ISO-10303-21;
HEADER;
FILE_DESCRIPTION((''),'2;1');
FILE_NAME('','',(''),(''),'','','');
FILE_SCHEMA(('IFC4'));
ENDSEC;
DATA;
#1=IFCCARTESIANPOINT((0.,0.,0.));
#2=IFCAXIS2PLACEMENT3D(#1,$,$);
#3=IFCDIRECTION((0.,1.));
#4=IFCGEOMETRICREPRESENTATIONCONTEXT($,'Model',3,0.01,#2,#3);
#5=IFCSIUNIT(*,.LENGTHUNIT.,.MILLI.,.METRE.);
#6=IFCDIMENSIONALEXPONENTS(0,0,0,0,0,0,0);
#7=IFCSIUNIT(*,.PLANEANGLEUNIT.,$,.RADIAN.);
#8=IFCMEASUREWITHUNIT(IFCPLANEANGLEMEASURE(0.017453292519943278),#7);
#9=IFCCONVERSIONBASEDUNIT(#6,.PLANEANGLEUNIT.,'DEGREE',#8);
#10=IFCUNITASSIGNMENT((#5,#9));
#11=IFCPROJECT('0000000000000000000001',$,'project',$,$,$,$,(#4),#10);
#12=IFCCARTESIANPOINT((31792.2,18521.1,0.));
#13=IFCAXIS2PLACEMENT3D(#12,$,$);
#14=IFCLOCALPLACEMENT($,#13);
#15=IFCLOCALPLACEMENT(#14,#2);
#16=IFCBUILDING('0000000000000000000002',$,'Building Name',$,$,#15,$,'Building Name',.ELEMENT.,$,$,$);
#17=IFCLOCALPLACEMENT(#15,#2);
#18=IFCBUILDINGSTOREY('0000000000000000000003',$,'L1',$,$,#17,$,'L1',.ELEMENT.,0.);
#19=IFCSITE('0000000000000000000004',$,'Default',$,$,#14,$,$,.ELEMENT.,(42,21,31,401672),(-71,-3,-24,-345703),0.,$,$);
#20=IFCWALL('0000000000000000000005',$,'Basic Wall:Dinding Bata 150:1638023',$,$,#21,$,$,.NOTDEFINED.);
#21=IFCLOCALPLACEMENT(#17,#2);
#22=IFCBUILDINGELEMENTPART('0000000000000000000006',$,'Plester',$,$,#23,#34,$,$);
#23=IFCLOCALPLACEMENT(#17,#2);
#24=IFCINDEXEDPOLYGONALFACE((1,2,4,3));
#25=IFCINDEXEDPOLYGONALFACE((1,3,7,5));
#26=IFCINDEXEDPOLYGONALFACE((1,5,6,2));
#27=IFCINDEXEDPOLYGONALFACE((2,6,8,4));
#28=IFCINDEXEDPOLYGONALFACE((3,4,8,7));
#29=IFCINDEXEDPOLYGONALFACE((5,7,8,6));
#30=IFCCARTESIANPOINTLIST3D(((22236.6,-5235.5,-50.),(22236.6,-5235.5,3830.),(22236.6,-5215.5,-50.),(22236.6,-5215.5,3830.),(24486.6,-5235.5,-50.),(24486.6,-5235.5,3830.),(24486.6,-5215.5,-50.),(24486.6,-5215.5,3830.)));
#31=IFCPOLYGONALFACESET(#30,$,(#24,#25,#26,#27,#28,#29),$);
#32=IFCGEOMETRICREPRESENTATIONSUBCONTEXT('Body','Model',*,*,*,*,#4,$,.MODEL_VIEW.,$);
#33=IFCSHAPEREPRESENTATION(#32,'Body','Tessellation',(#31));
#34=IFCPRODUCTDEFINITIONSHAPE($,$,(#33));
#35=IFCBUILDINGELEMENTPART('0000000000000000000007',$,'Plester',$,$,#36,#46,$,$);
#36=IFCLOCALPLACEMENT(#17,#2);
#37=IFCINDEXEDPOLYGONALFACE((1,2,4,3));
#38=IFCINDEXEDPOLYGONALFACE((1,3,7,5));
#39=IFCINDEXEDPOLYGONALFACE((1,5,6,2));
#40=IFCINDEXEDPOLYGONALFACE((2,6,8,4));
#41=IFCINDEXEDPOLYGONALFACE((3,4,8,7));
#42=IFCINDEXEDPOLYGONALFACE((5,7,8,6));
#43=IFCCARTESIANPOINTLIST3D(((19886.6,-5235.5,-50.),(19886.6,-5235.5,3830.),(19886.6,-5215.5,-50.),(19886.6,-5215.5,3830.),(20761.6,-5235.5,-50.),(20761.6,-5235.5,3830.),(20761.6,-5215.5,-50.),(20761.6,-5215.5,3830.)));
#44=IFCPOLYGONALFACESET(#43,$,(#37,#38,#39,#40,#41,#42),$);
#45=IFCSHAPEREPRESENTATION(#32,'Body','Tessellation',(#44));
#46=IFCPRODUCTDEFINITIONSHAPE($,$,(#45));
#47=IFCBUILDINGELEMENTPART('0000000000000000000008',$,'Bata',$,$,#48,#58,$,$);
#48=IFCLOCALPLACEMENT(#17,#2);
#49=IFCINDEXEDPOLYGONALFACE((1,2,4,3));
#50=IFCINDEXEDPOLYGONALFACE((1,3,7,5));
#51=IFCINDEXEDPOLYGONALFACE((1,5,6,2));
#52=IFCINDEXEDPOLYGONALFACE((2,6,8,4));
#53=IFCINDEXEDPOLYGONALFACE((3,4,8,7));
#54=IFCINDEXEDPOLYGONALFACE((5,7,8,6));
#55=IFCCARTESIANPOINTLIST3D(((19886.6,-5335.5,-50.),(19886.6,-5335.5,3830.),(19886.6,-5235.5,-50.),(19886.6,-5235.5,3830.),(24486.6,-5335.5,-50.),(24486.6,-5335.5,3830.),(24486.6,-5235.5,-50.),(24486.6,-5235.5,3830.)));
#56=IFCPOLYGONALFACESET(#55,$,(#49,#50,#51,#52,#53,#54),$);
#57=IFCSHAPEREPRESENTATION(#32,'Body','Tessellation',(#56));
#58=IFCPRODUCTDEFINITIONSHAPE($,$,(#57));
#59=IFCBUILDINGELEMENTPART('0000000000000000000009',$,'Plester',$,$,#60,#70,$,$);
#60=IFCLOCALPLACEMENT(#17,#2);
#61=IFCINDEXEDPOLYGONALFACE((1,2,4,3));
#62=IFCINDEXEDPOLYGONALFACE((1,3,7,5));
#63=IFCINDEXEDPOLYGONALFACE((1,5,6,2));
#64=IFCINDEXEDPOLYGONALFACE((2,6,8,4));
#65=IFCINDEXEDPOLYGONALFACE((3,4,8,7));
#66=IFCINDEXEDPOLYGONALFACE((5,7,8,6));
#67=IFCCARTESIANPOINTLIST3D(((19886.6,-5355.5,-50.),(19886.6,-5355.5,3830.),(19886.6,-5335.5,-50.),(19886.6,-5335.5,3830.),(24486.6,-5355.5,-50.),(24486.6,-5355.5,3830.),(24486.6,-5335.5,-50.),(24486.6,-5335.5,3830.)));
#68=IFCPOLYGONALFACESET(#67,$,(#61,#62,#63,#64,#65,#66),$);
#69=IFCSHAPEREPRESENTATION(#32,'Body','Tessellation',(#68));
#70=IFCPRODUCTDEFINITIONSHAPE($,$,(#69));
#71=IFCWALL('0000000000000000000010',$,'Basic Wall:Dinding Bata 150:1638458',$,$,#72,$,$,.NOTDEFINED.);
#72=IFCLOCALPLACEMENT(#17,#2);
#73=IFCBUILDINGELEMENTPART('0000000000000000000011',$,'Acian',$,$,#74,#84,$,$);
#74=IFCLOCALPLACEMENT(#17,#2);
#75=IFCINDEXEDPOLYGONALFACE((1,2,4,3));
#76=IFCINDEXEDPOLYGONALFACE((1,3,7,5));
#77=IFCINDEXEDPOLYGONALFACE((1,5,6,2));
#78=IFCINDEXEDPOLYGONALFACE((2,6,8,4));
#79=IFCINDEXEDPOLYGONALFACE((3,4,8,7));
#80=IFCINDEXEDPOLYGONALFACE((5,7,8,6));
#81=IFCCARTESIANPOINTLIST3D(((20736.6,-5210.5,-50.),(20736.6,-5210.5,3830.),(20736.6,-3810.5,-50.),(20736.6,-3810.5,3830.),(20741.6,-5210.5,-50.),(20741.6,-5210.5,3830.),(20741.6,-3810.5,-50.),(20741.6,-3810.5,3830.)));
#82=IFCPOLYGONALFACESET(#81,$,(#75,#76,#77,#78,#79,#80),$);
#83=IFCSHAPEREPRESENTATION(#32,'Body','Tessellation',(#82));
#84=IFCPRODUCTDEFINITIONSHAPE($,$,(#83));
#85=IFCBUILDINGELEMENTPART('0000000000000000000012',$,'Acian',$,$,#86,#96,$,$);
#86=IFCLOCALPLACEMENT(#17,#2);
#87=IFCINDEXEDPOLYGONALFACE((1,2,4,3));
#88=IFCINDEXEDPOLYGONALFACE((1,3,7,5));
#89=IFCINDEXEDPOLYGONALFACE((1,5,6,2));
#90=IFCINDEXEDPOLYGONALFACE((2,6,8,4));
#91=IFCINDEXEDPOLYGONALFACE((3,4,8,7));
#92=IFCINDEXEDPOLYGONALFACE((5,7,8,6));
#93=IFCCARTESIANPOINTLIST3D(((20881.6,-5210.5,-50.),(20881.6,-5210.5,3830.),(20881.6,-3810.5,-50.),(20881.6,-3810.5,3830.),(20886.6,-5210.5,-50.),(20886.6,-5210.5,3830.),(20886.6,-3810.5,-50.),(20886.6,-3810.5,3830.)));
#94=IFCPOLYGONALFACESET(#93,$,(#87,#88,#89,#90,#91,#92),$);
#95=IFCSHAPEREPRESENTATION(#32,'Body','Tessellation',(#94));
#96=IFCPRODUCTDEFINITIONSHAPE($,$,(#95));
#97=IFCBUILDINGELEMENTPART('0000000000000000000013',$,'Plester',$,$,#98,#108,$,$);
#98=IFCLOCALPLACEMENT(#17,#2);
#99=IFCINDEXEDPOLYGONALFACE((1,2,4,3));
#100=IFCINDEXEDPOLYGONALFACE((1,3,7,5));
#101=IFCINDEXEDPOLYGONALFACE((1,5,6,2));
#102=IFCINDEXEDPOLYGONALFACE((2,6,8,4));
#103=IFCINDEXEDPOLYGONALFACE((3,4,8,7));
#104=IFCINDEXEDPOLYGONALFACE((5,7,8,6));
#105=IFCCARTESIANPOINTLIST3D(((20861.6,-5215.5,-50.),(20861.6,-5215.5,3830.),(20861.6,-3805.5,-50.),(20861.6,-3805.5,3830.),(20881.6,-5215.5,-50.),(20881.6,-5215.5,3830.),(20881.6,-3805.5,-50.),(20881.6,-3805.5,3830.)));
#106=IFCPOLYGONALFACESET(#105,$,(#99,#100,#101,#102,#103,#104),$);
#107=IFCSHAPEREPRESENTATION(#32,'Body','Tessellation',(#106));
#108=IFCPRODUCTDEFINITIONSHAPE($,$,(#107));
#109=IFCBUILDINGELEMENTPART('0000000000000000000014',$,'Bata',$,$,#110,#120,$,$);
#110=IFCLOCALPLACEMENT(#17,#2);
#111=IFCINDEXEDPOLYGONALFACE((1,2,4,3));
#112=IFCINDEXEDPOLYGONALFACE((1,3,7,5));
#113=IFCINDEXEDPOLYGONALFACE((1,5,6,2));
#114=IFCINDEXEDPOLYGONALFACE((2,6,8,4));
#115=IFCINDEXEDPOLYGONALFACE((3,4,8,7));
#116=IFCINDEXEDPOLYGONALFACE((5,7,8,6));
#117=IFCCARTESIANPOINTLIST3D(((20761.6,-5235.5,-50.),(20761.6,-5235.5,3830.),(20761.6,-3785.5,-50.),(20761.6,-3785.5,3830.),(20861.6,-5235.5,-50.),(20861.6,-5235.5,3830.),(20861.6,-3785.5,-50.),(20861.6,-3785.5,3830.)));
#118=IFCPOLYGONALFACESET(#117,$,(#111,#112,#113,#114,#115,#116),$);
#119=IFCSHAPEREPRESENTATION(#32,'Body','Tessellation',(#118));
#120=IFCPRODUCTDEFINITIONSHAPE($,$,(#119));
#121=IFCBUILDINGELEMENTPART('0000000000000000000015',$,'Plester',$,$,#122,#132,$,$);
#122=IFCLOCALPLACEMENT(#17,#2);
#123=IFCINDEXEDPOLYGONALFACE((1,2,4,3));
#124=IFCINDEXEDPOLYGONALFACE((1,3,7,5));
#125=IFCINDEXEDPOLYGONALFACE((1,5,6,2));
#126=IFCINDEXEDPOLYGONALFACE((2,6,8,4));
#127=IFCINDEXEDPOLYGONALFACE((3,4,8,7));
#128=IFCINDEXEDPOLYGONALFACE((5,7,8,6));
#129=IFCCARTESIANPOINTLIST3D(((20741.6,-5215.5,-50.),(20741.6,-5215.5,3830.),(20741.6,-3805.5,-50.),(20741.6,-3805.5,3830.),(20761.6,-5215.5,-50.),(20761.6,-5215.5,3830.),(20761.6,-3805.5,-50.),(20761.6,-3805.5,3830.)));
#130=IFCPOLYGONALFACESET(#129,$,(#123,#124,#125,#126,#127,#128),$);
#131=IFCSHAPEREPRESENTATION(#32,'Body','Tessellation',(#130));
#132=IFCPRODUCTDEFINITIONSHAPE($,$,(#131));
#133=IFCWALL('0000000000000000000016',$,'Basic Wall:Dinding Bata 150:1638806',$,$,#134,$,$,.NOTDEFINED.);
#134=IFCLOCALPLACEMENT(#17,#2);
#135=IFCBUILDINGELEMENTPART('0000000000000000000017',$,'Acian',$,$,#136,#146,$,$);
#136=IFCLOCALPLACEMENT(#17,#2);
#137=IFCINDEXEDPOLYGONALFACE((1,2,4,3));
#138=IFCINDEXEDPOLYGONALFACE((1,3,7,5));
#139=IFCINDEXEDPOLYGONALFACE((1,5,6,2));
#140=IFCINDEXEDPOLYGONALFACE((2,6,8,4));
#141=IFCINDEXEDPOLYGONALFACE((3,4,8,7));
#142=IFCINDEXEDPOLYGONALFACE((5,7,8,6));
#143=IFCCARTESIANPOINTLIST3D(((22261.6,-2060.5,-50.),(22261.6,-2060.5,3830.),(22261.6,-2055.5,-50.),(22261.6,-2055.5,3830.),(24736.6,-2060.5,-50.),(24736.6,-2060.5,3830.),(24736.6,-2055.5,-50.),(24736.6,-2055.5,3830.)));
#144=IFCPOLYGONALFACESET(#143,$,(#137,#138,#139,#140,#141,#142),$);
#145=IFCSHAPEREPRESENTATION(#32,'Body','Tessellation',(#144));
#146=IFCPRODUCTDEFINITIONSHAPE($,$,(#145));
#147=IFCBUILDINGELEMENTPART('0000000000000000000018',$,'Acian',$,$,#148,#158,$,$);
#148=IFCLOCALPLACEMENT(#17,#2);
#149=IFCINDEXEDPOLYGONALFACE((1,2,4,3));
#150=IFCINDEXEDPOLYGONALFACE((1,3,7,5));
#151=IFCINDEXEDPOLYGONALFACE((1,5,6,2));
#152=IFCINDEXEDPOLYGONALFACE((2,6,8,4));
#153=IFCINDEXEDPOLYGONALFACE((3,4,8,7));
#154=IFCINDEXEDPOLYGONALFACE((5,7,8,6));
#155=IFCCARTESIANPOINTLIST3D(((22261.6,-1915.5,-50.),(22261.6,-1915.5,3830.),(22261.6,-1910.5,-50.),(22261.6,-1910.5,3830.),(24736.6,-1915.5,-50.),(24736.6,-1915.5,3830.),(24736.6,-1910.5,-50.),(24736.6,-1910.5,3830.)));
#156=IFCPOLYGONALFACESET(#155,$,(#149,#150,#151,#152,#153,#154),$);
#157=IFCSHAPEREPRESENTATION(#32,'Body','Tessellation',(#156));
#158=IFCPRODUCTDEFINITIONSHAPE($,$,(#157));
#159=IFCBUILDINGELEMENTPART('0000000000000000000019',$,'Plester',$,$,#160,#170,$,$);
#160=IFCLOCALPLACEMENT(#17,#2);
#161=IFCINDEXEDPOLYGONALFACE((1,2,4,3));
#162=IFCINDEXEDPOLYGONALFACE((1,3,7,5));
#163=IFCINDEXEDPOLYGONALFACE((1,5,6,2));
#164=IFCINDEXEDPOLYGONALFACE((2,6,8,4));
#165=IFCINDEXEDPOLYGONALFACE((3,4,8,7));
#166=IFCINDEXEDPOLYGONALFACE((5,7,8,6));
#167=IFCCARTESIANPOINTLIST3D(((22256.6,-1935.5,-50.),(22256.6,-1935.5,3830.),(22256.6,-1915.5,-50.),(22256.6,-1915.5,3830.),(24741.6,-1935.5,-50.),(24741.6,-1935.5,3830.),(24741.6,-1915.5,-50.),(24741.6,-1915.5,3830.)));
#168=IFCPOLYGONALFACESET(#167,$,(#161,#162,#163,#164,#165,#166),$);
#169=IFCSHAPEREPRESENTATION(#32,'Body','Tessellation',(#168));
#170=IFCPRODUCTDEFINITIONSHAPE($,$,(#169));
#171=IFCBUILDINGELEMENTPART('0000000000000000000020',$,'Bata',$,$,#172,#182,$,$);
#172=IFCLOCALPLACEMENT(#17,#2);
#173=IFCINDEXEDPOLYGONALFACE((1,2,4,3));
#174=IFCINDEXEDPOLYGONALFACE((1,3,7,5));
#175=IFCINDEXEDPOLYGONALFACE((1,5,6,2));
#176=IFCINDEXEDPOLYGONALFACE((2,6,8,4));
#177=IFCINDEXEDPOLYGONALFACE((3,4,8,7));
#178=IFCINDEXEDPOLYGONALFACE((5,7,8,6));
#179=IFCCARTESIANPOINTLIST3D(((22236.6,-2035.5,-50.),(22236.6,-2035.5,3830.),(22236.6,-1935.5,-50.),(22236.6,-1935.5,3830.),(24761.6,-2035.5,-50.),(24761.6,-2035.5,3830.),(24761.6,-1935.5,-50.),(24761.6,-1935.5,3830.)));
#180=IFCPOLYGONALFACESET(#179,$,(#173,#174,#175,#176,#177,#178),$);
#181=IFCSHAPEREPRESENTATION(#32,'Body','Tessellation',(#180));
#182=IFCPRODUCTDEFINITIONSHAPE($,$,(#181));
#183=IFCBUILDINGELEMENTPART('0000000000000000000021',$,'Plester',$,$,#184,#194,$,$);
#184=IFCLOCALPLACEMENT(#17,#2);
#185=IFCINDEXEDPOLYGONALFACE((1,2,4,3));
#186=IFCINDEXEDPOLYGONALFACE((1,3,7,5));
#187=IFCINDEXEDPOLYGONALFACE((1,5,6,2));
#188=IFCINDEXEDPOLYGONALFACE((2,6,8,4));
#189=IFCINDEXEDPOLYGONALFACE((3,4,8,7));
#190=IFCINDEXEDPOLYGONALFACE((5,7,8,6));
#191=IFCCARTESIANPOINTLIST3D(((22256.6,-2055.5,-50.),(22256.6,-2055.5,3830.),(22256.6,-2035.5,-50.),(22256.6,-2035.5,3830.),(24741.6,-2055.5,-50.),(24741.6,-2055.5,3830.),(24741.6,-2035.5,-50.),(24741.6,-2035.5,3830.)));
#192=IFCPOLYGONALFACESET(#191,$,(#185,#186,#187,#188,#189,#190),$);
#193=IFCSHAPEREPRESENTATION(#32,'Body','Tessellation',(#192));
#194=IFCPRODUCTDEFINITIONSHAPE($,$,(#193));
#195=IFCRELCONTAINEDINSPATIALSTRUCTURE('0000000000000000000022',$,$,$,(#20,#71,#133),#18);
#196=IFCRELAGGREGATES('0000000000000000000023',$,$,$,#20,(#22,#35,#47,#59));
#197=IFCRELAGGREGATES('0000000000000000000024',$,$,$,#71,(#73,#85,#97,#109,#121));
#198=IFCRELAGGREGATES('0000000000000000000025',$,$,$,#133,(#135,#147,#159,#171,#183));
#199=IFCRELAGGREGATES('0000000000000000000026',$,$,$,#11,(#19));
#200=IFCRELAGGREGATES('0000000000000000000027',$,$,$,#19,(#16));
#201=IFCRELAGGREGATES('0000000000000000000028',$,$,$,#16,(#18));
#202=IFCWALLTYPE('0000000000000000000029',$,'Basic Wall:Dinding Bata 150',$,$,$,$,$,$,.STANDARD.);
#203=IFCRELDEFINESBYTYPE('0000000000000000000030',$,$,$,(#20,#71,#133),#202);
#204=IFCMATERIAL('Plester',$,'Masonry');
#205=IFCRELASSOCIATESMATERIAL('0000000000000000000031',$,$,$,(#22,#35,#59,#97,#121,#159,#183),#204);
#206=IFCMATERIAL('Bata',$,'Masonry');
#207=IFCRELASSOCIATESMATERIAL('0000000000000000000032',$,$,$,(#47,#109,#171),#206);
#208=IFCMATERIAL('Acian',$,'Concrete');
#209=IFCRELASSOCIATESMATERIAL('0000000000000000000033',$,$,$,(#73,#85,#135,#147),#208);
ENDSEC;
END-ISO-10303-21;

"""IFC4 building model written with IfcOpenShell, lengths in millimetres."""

from ifc_helpers import new_model, entity, si_unit, converted_unit, direction, frame, origin, place, context, subcontext, project, spatial, indexed_curve, outline, extrude, material, type_object, element, aggregate, save


model = new_model("IFC4")

# Units and contexts
model_context = context("Model", 3, precision=0.01, world=origin(), true_north=direction((0.0, 1.0)))
body_context = subcontext(model_context, "Body", "Model", "MODEL_VIEW")
ifc_project = project(units=[si_unit("LENGTHUNIT", "METRE", prefix="MILLI"), converted_unit("PLANEANGLEUNIT", "DEGREE", entity("IfcPlaneAngleMeasure", 0.017453292519943278), si_unit("PLANEANGLEUNIT", "RADIAN"), dimensions=[0, 0, 0, 0, 0, 0, 0])], contexts=[model_context])

# Site, building, storey
site_placement = place(None, frame((31792.2, 18521.1, 0.0)))
site = spatial("IfcSite", under=ifc_project, at=site_placement, Name="Default", CompositionType="ELEMENT", RefLatitude=(42, 21, 31, 401672), RefLongitude=(-71, -3, -24, -345703), RefElevation=0.0)
building_placement = place(site_placement, origin())
building = spatial("IfcBuilding", under=site, at=building_placement, Name="Building Name", LongName="Building Name", CompositionType="ELEMENT")
storey_placement = place(building_placement, origin())
storey = spatial("IfcBuildingStorey", under=building, at=storey_placement, Name="L1", LongName="L1", CompositionType="ELEMENT", Elevation=0.0)

# Walls, building element parts
wall_type = type_object("IfcWallType", Name="Basic Wall:Dinding Bata 150", PredefinedType="STANDARD")
wall_1_placement = place(storey_placement, frame((19886.6, -5285.5, -50.0)))
wall_1 = element("IfcWall", 1, at=wall_1_placement, inside=storey, type_object=wall_type, Name="Basic Wall:Dinding Bata 150:1638023", PredefinedType="NOTDEFINED")
ifc_material_1 = material(Name="Plester", Category="Masonry")
building_element_part_1_placement = place(wall_1_placement, origin())
building_element_part_1 = element("IfcBuildingElementPart", 2, at=building_element_part_1_placement, material=ifc_material_1, Name="Plester", context=body_context, shape_type="SweptSolid", body=[
    extrude(outline(indexed_curve([(-10.0, -1125.0), (10.0, -1125.0), (10.0, 1125.0), (-10.0, 1125.0), (-10.0, -1125.0)], self_intersect=False)), frame((3475.0, 60.0, 0.0), z_axis=(0.0, 0.0, 1.0), x_axis=(0.0, -1.0, 0.0)), (0.0, 0.0, 1.0), 3880.0),
])
building_element_part_2_placement = place(wall_1_placement, origin())
building_element_part_2 = element("IfcBuildingElementPart", 3, at=building_element_part_2_placement, material=ifc_material_1, Name="Plester", context=body_context, shape_type="SweptSolid", body=[
    extrude(outline(indexed_curve([(-10.0, -437.5), (10.0, -437.5), (10.0, 437.5), (-10.0, 437.5), (-10.0, -437.5)], self_intersect=False)), frame((437.5, 60.0, 0.0), z_axis=(0.0, 0.0, 1.0), x_axis=(0.0, -1.0, 0.0)), (0.0, 0.0, 1.0), 3880.0),
])
ifc_material_2 = material(Name="Bata", Category="Masonry")
building_element_part_3_placement = place(wall_1_placement, origin())
building_element_part_3 = element("IfcBuildingElementPart", 4, at=building_element_part_3_placement, material=ifc_material_2, Name="Bata", context=body_context, shape_type="SweptSolid", body=[
    extrude(outline(indexed_curve([(-50.0, -2300.0), (50.0, -2300.0), (50.0, 2300.0), (-50.0, 2300.0), (-50.0, -2300.0)], self_intersect=False)), frame((2300.0, 0.0, 0.0), z_axis=(0.0, 0.0, 1.0), x_axis=(0.0, -1.0, 0.0)), (0.0, 0.0, 1.0), 3880.0),
])
building_element_part_4_placement = place(wall_1_placement, origin())
building_element_part_4 = element("IfcBuildingElementPart", 5, at=building_element_part_4_placement, material=ifc_material_1, Name="Plester", context=body_context, shape_type="SweptSolid", body=[
    extrude(outline(indexed_curve([(-10.0, -2300.0), (10.0, -2300.0), (10.0, 2300.0), (-10.0, 2300.0), (-10.0, -2300.0)], self_intersect=False)), frame((2300.0, -60.0, 0.0), z_axis=(0.0, 0.0, 1.0), x_axis=(0.0, -1.0, 0.0)), (0.0, 0.0, 1.0), 3880.0),
])
aggregate(wall_1, [building_element_part_1, building_element_part_2, building_element_part_3, building_element_part_4])
wall_2_placement = place(storey_placement, frame((20811.6, -3810.5, -50.0), z_axis=(0.0, 0.0, 1.0), x_axis=(0.0, -1.0, 0.0)))
wall_2 = element("IfcWall", 6, at=wall_2_placement, inside=storey, type_object=wall_type, Name="Basic Wall:Dinding Bata 150:1638458", PredefinedType="NOTDEFINED")
ifc_material_3 = material(Name="Acian", Category="Concrete")
building_element_part_5_placement = place(wall_2_placement, origin())
building_element_part_5 = element("IfcBuildingElementPart", 7, at=building_element_part_5_placement, material=ifc_material_3, Name="Acian", context=body_context, shape_type="SweptSolid", body=[
    extrude(outline(indexed_curve([(-700.0, -2.5), (700.0, -2.5), (700.0, 2.5), (-700.0, 2.5), (-700.0, -2.5)], self_intersect=False)), frame((700.0, -72.5, 0.0)), (0.0, 0.0, 1.0), 3880.0),
])
building_element_part_6_placement = place(wall_2_placement, origin())
building_element_part_6 = element("IfcBuildingElementPart", 8, at=building_element_part_6_placement, material=ifc_material_3, Name="Acian", context=body_context, shape_type="SweptSolid", body=[
    extrude(outline(indexed_curve([(-700.0, -2.5), (700.0, -2.5), (700.0, 2.5), (-700.0, 2.5), (-700.0, -2.5)], self_intersect=False)), frame((700.0, 72.5, 0.0)), (0.0, 0.0, 1.0), 3880.0),
])
building_element_part_7_placement = place(wall_2_placement, origin())
building_element_part_7 = element("IfcBuildingElementPart", 9, at=building_element_part_7_placement, material=ifc_material_1, Name="Plester", context=body_context, shape_type="SweptSolid", body=[
    extrude(outline(indexed_curve([(-705.0, -10.0), (705.0, -10.0), (705.0, 10.0), (-705.0, 10.0), (-705.0, -10.0)], self_intersect=False)), frame((700.0, 60.0, 0.0)), (0.0, 0.0, 1.0), 3880.0),
])
building_element_part_8_placement = place(wall_2_placement, origin())
building_element_part_8 = element("IfcBuildingElementPart", 10, at=building_element_part_8_placement, material=ifc_material_2, Name="Bata", context=body_context, shape_type="SweptSolid", body=[
    extrude(outline(indexed_curve([(-725.0, -50.0), (725.0, -50.0), (725.0, 50.0), (-725.0, 50.0), (-725.0, -50.0)], self_intersect=False)), frame((700.0, 0.0, 0.0)), (0.0, 0.0, 1.0), 3880.0),
])
building_element_part_9_placement = place(wall_2_placement, origin())
building_element_part_9 = element("IfcBuildingElementPart", 11, at=building_element_part_9_placement, material=ifc_material_1, Name="Plester", context=body_context, shape_type="SweptSolid", body=[
    extrude(outline(indexed_curve([(-705.0, -10.0), (705.0, -10.0), (705.0, 10.0), (-705.0, 10.0), (-705.0, -10.0)], self_intersect=False)), frame((700.0, -60.0, 0.0)), (0.0, 0.0, 1.0), 3880.0),
])
aggregate(wall_2, [building_element_part_5, building_element_part_6, building_element_part_7, building_element_part_8, building_element_part_9])
wall_3_placement = place(storey_placement, frame((22261.6, -1985.5, -50.0)))
wall_3 = element("IfcWall", 12, at=wall_3_placement, inside=storey, type_object=wall_type, Name="Basic Wall:Dinding Bata 150:1638806", PredefinedType="NOTDEFINED")
building_element_part_10_placement = place(wall_3_placement, origin())
building_element_part_10 = element("IfcBuildingElementPart", 13, at=building_element_part_10_placement, material=ifc_material_3, Name="Acian", context=body_context, shape_type="SweptSolid", body=[
    extrude(outline(indexed_curve([(-2.5, -1237.5), (2.5, -1237.5), (2.5, 1237.5), (-2.5, 1237.5), (-2.5, -1237.5)], self_intersect=False)), frame((1237.5, -72.5, 0.0), z_axis=(0.0, 0.0, 1.0), x_axis=(0.0, -1.0, 0.0)), (0.0, 0.0, 1.0), 3880.0),
])
building_element_part_11_placement = place(wall_3_placement, origin())
building_element_part_11 = element("IfcBuildingElementPart", 14, at=building_element_part_11_placement, material=ifc_material_3, Name="Acian", context=body_context, shape_type="SweptSolid", body=[
    extrude(outline(indexed_curve([(-2.5, -1237.5), (2.5, -1237.5), (2.5, 1237.5), (-2.5, 1237.5), (-2.5, -1237.5)], self_intersect=False)), frame((1237.5, 72.5, 0.0), z_axis=(0.0, 0.0, 1.0), x_axis=(0.0, -1.0, 0.0)), (0.0, 0.0, 1.0), 3880.0),
])
building_element_part_12_placement = place(wall_3_placement, origin())
building_element_part_12 = element("IfcBuildingElementPart", 15, at=building_element_part_12_placement, material=ifc_material_1, Name="Plester", context=body_context, shape_type="SweptSolid", body=[
    extrude(outline(indexed_curve([(-10.0, -1242.5), (10.0, -1242.5), (10.0, 1242.5), (-10.0, 1242.5), (-10.0, -1242.5)], self_intersect=False)), frame((1237.5, 60.0, 0.0), z_axis=(0.0, 0.0, 1.0), x_axis=(0.0, -1.0, 0.0)), (0.0, 0.0, 1.0), 3880.0),
])
building_element_part_13_placement = place(wall_3_placement, origin())
building_element_part_13 = element("IfcBuildingElementPart", 16, at=building_element_part_13_placement, material=ifc_material_2, Name="Bata", context=body_context, shape_type="SweptSolid", body=[
    extrude(outline(indexed_curve([(-50.0, -1262.5), (50.0, -1262.5), (50.0, 1262.5), (-50.0, 1262.5), (-50.0, -1262.5)], self_intersect=False)), frame((1237.5, 0.0, 0.0), z_axis=(0.0, 0.0, 1.0), x_axis=(0.0, -1.0, 0.0)), (0.0, 0.0, 1.0), 3880.0),
])
building_element_part_14_placement = place(wall_3_placement, origin())
building_element_part_14 = element("IfcBuildingElementPart", 17, at=building_element_part_14_placement, material=ifc_material_1, Name="Plester", context=body_context, shape_type="SweptSolid", body=[
    extrude(outline(indexed_curve([(-10.0, -1242.5), (10.0, -1242.5), (10.0, 1242.5), (-10.0, 1242.5), (-10.0, -1242.5)], self_intersect=False)), frame((1237.5, -60.0, 0.0), z_axis=(0.0, 0.0, 1.0), x_axis=(0.0, -1.0, 0.0)), (0.0, 0.0, 1.0), 3880.0),
])
aggregate(wall_3, [building_element_part_10, building_element_part_11, building_element_part_12, building_element_part_13, building_element_part_14])

save(model, "model.ifc")
